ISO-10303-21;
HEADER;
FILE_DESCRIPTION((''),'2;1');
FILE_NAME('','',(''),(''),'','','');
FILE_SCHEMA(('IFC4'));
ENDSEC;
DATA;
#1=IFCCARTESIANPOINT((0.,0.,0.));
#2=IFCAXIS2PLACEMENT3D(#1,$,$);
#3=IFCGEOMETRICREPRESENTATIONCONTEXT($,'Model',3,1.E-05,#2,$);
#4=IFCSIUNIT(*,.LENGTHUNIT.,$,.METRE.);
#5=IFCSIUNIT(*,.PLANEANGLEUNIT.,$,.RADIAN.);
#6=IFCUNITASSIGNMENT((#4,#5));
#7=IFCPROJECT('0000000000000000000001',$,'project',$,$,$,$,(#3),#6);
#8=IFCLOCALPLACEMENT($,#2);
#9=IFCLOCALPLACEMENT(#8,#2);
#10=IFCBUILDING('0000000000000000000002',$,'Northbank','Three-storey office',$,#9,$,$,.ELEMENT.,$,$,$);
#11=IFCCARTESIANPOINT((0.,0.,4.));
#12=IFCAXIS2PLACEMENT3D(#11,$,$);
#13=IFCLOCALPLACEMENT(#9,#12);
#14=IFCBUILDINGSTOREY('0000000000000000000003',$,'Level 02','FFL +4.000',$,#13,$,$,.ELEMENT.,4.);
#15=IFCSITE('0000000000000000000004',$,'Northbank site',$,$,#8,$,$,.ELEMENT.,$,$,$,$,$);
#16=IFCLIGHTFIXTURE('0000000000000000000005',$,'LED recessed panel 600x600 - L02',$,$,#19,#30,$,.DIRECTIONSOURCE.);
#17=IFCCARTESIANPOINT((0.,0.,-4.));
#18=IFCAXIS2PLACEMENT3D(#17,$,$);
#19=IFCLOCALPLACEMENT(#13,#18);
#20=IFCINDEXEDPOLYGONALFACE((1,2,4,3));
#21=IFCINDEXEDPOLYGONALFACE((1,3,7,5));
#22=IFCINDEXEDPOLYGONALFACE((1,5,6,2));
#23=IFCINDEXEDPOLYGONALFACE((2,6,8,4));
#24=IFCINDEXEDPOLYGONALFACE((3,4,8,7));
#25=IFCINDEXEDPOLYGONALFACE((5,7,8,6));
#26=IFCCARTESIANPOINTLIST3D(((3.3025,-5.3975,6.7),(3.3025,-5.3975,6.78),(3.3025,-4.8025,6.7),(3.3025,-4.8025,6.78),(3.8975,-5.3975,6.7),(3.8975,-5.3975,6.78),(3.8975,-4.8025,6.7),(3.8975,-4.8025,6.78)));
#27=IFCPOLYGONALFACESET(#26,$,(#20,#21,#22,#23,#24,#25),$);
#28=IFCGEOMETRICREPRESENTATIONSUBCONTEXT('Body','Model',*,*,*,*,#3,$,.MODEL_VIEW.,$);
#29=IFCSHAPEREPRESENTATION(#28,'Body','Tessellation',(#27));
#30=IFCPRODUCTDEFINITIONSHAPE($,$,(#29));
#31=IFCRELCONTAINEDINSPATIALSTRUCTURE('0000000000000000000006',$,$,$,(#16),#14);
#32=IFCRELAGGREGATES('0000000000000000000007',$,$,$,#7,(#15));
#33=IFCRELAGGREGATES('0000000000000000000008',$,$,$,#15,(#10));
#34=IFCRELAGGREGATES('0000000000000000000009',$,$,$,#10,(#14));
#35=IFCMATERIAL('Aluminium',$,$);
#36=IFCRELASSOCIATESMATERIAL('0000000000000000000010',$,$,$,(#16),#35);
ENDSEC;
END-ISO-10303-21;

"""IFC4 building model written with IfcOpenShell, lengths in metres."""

from ifc_helpers import new_model, si_unit, frame, origin, place, context, subcontext, project, spatial, rectangle, extrude, material, element, save


model = new_model("IFC4")

# Units and contexts
model_context = context("Model", 3, precision=1e-05, world=origin())
body_context = subcontext(model_context, "Body", "Model", "MODEL_VIEW")
ifc_project = project(units=[si_unit("LENGTHUNIT", "METRE"), si_unit("PLANEANGLEUNIT", "RADIAN")], contexts=[model_context])

# Site, building, storey
site_placement = place(None, origin())
site = spatial("IfcSite", under=ifc_project, at=site_placement, Name="Northbank site", CompositionType="ELEMENT")
building_placement = place(site_placement, origin())
building = spatial("IfcBuilding", under=site, at=building_placement, Name="Northbank", Description="Three-storey office", CompositionType="ELEMENT")
storey_placement = place(building_placement, frame((0.0, 0.0, 4.0)))
storey = spatial("IfcBuildingStorey", under=building, at=storey_placement, Name="Level 02", Description="FFL +4.000", CompositionType="ELEMENT", Elevation=4.0)

# Light fixture
ifc_material_1 = material(Name="Aluminium")
light_fixture_1_placement = place(storey_placement, frame((0.0, 0.0, -4.0)))
element("IfcLightFixture", 1, at=light_fixture_1_placement, inside=storey, material=ifc_material_1, Name="LED recessed panel 600x600 - L02", PredefinedType="DIRECTIONSOURCE", context=body_context, shape_type="SweptSolid", body=[
    extrude(rectangle(XDim=0.595, YDim=0.595), frame((3.6, -5.1, 6.7)), (0.0, 0.0, 1.0), 0.08),
])

save(model, "model.ifc")
